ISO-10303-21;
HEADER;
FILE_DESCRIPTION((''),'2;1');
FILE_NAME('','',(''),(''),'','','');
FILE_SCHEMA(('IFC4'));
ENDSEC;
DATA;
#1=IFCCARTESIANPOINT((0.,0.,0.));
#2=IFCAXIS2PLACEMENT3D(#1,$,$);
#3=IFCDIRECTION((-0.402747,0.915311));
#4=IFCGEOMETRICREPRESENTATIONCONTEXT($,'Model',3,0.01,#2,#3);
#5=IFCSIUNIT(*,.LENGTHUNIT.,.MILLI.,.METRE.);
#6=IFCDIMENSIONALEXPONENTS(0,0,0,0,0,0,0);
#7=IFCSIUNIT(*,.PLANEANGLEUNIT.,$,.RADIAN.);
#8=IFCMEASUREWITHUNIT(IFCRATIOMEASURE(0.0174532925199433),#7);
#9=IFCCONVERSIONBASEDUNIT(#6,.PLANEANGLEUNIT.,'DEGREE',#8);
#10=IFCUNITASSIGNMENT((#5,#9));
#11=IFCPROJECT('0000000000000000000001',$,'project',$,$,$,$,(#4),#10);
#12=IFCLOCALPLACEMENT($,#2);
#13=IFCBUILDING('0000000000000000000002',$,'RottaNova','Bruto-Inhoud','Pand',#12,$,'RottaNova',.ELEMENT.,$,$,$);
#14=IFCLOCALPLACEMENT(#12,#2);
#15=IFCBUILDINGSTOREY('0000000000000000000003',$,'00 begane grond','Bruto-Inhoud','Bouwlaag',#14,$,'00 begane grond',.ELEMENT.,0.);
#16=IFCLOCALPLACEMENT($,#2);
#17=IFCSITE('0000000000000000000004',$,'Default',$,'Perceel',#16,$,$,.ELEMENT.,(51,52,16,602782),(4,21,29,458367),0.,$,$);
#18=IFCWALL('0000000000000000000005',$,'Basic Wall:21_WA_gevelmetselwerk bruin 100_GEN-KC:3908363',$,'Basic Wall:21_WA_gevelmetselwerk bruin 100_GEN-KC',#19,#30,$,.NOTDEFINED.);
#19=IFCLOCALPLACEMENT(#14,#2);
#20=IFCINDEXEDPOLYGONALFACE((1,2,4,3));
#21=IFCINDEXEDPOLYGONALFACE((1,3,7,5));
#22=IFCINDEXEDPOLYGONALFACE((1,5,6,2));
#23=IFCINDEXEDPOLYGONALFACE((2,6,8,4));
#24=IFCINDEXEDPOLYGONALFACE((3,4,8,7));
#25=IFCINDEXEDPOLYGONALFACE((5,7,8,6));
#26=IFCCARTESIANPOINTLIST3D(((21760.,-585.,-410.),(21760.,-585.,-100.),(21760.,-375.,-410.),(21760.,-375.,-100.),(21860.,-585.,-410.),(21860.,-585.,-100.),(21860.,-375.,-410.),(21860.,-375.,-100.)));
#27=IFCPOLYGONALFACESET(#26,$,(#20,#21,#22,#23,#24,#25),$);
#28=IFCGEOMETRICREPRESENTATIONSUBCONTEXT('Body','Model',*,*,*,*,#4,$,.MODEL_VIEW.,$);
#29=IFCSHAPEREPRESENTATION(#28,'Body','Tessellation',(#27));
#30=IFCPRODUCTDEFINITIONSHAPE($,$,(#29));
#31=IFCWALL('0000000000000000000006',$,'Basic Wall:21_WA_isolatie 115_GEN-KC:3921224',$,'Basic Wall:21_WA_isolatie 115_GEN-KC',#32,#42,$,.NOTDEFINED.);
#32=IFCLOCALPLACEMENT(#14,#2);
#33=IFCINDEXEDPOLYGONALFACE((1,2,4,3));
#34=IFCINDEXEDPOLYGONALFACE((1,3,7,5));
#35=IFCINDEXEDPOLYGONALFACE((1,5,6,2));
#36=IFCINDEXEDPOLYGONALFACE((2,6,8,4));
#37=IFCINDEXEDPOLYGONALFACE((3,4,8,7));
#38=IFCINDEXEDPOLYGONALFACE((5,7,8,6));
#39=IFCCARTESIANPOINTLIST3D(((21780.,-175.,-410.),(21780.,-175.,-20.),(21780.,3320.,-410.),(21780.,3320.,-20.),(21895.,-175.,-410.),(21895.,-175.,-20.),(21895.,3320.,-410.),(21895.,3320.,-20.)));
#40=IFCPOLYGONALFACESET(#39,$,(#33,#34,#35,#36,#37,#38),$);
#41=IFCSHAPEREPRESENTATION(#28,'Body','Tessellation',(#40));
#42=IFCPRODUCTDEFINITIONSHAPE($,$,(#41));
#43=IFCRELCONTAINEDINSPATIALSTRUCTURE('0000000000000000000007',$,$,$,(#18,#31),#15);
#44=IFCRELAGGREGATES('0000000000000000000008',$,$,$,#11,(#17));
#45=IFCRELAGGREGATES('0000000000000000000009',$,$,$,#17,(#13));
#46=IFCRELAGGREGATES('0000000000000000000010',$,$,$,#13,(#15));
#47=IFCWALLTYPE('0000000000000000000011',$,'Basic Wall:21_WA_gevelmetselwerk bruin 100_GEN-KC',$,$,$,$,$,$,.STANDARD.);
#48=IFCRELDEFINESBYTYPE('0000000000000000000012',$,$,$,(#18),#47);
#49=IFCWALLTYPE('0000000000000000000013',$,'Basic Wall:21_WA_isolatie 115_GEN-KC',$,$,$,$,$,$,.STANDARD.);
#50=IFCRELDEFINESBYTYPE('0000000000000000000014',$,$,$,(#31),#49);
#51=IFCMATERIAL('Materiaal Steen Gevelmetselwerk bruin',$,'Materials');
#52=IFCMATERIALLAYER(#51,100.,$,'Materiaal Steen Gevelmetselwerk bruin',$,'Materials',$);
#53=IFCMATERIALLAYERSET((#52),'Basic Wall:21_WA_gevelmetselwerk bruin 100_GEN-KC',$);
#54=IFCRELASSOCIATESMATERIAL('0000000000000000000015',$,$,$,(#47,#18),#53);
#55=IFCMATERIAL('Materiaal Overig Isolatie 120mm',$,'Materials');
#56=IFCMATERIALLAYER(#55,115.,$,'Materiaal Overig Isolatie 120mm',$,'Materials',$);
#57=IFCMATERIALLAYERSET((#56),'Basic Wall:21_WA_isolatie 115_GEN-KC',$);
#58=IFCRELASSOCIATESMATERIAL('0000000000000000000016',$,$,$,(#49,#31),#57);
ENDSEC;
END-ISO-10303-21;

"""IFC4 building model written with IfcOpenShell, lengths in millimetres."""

from ifc_helpers import new_model, entity, si_unit, converted_unit, direction, frame, frame_2d, origin, place, context, subcontext, project, spatial, rectangle, extrude, material, layer, layer_set, type_object, element, save


model = new_model("IFC4")

# Units and contexts
model_context = context("Model", 3, precision=0.01, world=origin(), true_north=direction((-0.402747, 0.915311)))
body_context = subcontext(model_context, "Body", "Model", "MODEL_VIEW")
ifc_project = project(units=[si_unit("LENGTHUNIT", "METRE", prefix="MILLI"), converted_unit("PLANEANGLEUNIT", "DEGREE", entity("IfcRatioMeasure", 0.0174532925199433), si_unit("PLANEANGLEUNIT", "RADIAN"), dimensions=[0, 0, 0, 0, 0, 0, 0])], contexts=[model_context])

# Site, building, storey
site_placement = place(None, origin())
site = spatial("IfcSite", under=ifc_project, at=site_placement, Name="Default", ObjectType="Perceel", CompositionType="ELEMENT", RefLatitude=(51, 52, 16, 602782), RefLongitude=(4, 21, 29, 458367), RefElevation=0.0)
building_placement = place(None, origin())
building = spatial("IfcBuilding", under=site, at=building_placement, Name="RottaNova", Description="Bruto-Inhoud", ObjectType="Pand", LongName="RottaNova", CompositionType="ELEMENT")
storey_placement = place(building_placement, origin())
storey = spatial("IfcBuildingStorey", under=building, at=storey_placement, Name="00 begane grond", Description="Bruto-Inhoud", ObjectType="Bouwlaag", LongName="00 begane grond", CompositionType="ELEMENT", Elevation=0.0)

# Walls
ifc_material_1 = material(Name="Materiaal Steen Gevelmetselwerk bruin", Category="Materials")
ifc_layer_1 = layer(ifc_material_1, 100.0, Name="Materiaal Steen Gevelmetselwerk bruin", Category="Materials")
ifc_layer_set_1 = layer_set([ifc_layer_1], Name="Basic Wall:21_WA_gevelmetselwerk bruin 100_GEN-KC")
wall_type_1 = type_object("IfcWallType", Name="Basic Wall:21_WA_gevelmetselwerk bruin 100_GEN-KC", PredefinedType="STANDARD", material=ifc_layer_set_1)
wall_1_placement = place(storey_placement, frame((21810.0, -585.0, -410.0), z_axis=(0.0, 0.0, 1.0), x_axis=(0.0, 1.0, 0.0)))
element("IfcWall", 1, at=wall_1_placement, inside=storey, type_object=wall_type_1, material=ifc_layer_set_1, Name="Basic Wall:21_WA_gevelmetselwerk bruin 100_GEN-KC:3908363", ObjectType="Basic Wall:21_WA_gevelmetselwerk bruin 100_GEN-KC", PredefinedType="NOTDEFINED", context=body_context, shape_type="SweptSolid", body=[
    extrude(rectangle(XDim=210.0, YDim=100.0, at=frame_2d((105.0, 0.0), x_axis=(-1.0, 0.0))), origin(), (0.0, 0.0, 1.0), 310.0),
])
ifc_material_2 = material(Name="Materiaal Overig Isolatie 120mm", Category="Materials")
ifc_layer_2 = layer(ifc_material_2, 115.0, Name="Materiaal Overig Isolatie 120mm", Category="Materials")
ifc_layer_set_2 = layer_set([ifc_layer_2], Name="Basic Wall:21_WA_isolatie 115_GEN-KC")
wall_type_2 = type_object("IfcWallType", Name="Basic Wall:21_WA_isolatie 115_GEN-KC", PredefinedType="STANDARD", material=ifc_layer_set_2)
wall_2_placement = place(storey_placement, frame((21837.5, -175.0, -410.0), z_axis=(0.0, 0.0, 1.0), x_axis=(0.0, 1.0, 0.0)))
element("IfcWall", 2, at=wall_2_placement, inside=storey, type_object=wall_type_2, material=ifc_layer_set_2, Name="Basic Wall:21_WA_isolatie 115_GEN-KC:3921224", ObjectType="Basic Wall:21_WA_isolatie 115_GEN-KC", PredefinedType="NOTDEFINED", context=body_context, shape_type="SweptSolid", body=[
    extrude(rectangle(XDim=3495.0, YDim=115.0, at=frame_2d((1747.5, 0.0), x_axis=(-1.0, 0.0))), origin(), (0.0, 0.0, 1.0), 390.0),
])

save(model, "model.ifc")
